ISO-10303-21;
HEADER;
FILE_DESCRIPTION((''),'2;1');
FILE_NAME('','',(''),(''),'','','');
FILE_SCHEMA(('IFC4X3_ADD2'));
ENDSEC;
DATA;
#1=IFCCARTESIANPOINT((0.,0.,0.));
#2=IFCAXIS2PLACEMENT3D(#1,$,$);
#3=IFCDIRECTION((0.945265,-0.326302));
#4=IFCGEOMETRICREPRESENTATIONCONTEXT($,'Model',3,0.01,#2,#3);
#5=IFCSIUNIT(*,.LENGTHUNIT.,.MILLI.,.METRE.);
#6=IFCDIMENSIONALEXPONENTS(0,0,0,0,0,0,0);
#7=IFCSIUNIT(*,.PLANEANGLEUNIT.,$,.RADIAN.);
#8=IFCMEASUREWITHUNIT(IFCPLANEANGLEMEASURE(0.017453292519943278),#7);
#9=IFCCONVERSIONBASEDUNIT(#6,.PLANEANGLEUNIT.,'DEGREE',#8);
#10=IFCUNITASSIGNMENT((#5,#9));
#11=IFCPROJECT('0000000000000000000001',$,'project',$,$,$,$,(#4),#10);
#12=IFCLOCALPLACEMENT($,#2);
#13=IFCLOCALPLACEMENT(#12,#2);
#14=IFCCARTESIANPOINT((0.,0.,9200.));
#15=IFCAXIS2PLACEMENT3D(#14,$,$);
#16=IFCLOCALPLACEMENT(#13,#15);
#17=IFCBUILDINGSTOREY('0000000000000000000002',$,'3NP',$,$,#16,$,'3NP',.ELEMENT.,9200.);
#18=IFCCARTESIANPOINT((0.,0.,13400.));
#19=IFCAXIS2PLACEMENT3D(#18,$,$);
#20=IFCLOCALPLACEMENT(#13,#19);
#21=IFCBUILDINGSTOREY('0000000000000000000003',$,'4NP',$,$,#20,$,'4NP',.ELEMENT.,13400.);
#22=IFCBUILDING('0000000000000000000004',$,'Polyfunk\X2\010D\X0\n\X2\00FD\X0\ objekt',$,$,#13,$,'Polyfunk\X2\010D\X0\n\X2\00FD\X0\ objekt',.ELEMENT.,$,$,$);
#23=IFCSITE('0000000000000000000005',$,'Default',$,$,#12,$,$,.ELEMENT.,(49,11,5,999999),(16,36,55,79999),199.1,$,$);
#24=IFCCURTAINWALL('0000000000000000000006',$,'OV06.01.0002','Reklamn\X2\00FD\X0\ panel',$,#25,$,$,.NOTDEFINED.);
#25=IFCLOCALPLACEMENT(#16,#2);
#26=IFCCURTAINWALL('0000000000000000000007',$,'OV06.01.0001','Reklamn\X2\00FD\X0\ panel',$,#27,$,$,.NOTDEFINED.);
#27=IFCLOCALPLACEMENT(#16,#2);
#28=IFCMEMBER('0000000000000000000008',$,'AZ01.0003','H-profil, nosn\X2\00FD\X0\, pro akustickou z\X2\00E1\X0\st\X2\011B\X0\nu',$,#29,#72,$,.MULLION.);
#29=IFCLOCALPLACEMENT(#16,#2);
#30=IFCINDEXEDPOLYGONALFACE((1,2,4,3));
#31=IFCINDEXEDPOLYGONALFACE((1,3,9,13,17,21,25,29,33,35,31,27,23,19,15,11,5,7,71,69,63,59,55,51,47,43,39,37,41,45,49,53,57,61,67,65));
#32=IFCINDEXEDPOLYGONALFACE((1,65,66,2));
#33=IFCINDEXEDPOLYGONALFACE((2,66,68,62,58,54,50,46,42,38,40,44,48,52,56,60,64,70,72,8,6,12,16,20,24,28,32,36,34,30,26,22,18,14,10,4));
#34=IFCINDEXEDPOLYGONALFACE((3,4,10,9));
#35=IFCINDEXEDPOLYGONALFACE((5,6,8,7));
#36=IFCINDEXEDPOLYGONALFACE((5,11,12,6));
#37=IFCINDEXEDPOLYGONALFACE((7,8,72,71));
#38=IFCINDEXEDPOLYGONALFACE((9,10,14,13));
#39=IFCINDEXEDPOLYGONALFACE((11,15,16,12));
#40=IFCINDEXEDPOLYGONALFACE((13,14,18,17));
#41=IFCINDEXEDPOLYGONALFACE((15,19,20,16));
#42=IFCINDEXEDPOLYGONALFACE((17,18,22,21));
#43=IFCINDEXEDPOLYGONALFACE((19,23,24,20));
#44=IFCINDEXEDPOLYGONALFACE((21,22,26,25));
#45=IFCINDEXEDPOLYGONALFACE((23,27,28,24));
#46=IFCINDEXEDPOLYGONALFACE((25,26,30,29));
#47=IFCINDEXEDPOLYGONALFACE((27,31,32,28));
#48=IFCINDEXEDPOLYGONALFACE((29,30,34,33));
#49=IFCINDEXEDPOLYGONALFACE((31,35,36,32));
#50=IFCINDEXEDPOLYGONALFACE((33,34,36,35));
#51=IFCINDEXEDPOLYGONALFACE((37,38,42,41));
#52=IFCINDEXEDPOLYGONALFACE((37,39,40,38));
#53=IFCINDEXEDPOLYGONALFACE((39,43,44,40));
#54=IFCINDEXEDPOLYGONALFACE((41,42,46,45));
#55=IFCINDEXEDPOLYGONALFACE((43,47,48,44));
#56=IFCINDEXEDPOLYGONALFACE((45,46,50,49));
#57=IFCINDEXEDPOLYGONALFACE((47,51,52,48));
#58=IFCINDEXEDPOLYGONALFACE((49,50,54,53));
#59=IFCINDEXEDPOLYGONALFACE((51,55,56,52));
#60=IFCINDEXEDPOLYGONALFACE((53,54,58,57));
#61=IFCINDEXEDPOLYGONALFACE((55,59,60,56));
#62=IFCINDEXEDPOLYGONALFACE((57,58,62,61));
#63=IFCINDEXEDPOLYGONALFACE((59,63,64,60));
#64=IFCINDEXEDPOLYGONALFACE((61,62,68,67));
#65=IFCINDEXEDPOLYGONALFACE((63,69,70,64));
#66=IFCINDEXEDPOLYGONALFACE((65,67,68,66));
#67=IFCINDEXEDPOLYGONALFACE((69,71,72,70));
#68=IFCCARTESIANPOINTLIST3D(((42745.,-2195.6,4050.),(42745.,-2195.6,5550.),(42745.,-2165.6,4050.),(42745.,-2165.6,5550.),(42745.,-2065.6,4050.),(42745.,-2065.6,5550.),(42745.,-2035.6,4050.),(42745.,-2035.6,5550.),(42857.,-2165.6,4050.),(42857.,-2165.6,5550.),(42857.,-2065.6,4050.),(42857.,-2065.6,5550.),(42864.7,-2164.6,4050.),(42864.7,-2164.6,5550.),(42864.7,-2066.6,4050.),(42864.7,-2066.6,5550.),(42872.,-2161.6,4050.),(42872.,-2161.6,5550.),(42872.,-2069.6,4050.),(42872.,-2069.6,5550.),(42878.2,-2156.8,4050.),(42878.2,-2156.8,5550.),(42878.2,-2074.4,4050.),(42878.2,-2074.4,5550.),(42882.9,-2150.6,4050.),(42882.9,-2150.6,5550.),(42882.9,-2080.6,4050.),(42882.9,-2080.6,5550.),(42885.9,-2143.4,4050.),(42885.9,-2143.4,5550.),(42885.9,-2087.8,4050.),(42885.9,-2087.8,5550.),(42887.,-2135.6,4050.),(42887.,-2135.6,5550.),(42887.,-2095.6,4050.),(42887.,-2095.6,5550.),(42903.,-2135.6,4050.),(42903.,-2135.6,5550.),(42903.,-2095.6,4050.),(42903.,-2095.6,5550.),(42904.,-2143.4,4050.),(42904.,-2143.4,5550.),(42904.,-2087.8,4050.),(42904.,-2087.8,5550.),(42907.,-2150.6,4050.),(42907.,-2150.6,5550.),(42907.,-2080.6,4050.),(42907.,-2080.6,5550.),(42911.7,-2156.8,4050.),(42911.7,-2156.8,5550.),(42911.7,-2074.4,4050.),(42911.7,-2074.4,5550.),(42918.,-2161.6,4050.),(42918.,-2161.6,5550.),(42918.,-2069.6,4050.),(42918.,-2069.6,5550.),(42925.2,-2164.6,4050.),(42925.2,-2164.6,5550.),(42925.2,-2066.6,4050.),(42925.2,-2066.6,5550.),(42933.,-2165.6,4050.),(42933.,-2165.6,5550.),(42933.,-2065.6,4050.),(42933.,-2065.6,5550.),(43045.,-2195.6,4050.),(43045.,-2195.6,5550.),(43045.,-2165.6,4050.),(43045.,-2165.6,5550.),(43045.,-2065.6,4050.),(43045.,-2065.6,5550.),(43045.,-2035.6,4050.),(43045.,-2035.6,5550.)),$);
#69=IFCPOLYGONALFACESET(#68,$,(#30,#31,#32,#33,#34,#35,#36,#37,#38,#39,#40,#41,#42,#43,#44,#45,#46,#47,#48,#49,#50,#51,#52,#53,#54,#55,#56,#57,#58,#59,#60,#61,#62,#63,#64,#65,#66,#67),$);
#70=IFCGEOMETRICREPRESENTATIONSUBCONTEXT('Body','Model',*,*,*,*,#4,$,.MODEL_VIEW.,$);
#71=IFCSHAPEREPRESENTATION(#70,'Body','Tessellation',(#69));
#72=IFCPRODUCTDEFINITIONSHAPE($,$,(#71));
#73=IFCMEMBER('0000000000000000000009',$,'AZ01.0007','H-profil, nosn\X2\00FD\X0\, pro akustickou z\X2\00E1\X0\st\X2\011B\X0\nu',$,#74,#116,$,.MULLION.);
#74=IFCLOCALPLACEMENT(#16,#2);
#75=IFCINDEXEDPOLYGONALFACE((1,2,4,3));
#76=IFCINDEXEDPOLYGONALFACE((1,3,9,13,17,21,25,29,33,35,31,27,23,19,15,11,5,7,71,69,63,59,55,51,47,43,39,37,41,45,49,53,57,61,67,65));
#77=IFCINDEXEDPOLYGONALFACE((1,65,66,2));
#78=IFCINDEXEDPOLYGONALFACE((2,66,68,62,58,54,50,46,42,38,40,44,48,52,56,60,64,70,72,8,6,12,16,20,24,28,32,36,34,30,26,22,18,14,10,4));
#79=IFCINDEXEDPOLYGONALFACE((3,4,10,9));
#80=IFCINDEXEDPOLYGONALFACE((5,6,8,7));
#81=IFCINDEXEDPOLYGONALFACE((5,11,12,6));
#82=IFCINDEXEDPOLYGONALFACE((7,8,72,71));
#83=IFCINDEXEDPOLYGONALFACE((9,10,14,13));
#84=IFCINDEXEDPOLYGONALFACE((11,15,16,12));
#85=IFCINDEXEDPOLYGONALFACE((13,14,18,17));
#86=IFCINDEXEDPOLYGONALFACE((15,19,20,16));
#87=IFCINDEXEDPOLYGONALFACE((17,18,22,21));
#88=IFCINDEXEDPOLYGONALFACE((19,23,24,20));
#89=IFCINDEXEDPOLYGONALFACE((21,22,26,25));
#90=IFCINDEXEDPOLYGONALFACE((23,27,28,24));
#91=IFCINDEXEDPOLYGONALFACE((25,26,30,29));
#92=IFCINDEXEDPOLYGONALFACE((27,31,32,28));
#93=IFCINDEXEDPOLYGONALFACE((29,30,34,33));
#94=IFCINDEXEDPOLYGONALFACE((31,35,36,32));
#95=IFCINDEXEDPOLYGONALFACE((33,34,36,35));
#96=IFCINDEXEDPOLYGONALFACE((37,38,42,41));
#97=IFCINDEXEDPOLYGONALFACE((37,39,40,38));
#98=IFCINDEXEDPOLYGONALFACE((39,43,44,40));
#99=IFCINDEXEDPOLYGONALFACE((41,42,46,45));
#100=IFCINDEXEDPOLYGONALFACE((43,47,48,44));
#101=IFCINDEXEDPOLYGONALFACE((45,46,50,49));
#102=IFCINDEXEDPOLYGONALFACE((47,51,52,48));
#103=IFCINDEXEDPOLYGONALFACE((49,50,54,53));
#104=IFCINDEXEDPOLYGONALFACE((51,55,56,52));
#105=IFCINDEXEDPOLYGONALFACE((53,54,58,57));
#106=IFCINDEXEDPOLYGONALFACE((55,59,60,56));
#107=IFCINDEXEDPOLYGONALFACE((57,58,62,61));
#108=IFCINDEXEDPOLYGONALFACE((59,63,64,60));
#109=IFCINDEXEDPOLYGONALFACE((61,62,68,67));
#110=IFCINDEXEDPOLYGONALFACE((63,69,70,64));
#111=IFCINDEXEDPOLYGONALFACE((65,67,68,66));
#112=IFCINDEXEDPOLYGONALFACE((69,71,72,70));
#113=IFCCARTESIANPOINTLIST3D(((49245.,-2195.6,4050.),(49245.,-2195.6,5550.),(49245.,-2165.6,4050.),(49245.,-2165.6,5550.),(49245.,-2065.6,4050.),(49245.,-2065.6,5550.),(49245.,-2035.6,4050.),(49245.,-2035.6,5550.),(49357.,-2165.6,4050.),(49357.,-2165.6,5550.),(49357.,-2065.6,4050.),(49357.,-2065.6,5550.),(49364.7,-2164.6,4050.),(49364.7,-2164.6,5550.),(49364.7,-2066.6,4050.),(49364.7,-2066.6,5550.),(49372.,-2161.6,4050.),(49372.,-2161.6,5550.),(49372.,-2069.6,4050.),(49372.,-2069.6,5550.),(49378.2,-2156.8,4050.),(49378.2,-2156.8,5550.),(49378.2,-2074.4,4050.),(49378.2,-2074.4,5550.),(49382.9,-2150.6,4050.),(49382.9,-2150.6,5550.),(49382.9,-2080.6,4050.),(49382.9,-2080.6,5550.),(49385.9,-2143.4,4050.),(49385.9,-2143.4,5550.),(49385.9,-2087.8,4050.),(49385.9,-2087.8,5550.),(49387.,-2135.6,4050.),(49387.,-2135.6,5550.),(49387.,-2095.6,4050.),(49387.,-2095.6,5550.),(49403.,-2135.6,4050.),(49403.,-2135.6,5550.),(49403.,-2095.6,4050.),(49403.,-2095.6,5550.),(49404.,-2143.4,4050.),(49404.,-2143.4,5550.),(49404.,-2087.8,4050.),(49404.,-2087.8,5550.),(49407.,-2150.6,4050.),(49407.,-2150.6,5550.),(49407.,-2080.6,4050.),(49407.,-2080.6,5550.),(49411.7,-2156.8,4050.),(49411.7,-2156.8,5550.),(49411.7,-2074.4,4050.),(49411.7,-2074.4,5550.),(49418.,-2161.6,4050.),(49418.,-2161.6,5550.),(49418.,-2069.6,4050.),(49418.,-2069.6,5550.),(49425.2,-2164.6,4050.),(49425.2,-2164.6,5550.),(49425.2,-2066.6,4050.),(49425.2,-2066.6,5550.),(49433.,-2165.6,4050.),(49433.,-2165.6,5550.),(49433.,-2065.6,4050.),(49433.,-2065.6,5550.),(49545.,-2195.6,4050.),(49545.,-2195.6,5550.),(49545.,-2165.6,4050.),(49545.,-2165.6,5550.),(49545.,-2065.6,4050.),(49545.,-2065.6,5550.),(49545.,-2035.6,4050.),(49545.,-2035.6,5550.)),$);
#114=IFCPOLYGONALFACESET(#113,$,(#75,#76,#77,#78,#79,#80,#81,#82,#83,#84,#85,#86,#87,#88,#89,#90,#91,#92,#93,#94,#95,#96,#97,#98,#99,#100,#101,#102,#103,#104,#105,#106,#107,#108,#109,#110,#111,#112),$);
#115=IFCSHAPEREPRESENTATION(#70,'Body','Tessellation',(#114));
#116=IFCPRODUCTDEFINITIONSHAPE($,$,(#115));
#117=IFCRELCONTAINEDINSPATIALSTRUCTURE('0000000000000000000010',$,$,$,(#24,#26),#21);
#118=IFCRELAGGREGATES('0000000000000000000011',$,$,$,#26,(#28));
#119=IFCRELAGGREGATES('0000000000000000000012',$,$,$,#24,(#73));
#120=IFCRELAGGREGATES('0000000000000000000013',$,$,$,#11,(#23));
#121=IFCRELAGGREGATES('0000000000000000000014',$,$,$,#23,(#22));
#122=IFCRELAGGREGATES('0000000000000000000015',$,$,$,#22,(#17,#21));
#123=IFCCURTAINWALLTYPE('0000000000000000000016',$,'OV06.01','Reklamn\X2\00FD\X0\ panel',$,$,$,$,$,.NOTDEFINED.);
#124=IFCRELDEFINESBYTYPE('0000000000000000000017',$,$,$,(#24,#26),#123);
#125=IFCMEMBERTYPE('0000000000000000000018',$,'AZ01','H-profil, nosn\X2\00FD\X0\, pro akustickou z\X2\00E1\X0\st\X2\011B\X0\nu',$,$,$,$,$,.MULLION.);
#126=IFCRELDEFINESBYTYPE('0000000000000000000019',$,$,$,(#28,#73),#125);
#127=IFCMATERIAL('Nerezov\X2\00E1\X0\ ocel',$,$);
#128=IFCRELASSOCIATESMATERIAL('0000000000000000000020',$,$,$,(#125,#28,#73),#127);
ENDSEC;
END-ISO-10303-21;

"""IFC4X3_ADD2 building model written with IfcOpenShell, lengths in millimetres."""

from ifc_helpers import new_model, entity, si_unit, converted_unit, direction, frame, frame_2d, origin, place, context, subcontext, project, spatial, polyline, circle_curve, parameter, trimmed, segment, composite_curve, outline, extrude, source, transform, mapped, material, material_profile, profile_set, profile_usage, type_object, element, aggregate, save


model = new_model("IFC4X3_ADD2")

# Units and contexts
model_context = context("Model", 3, precision=0.01, world=origin(), true_north=direction((0.945265, -0.326302)))
body_context = subcontext(model_context, "Body", "Model", "MODEL_VIEW")
ifc_project = project(units=[si_unit("LENGTHUNIT", "METRE", prefix="MILLI"), converted_unit("PLANEANGLEUNIT", "DEGREE", entity("IfcPlaneAngleMeasure", 0.017453292519943278), si_unit("PLANEANGLEUNIT", "RADIAN"), dimensions=[0, 0, 0, 0, 0, 0, 0])], contexts=[model_context])

# Site, building, storey
site_placement = place(None, origin())
site = spatial("IfcSite", under=ifc_project, at=site_placement, Name="Default", CompositionType="ELEMENT", RefLatitude=(49, 11, 5, 999999), RefLongitude=(16, 36, 55, 79999), RefElevation=199.1)
building_placement = place(site_placement, origin())
building = spatial("IfcBuilding", under=site, at=building_placement, Name="Polyfunkčný objekt", LongName="Polyfunkčný objekt", CompositionType="ELEMENT")
storey_1_placement = place(building_placement, frame((0.0, 0.0, 9200.0)))
storey_1 = spatial("IfcBuildingStorey", under=building, at=storey_1_placement, Name="3NP", LongName="3NP", CompositionType="ELEMENT", Elevation=9200.0)

# Shared definitions
storey_2_placement = place(building_placement, frame((0.0, 0.0, 13400.0)))
storey_2 = spatial("IfcBuildingStorey", under=building, at=storey_2_placement, Name="4NP", LongName="4NP", CompositionType="ELEMENT", Elevation=13400.0)

# Shared definitions
ifc_material_1 = material(Name="Nerezová ocel")
ifc_material_profile_1 = material_profile(ifc_material_1, outline(composite_curve([segment(polyline([(50.0, -150.0), (80.0, -150.0)]), True, "CONTINUOUS"), segment(polyline([(80.0, -150.0), (80.0, 150.0)]), True, "CONTINUOUS"), segment(polyline([(80.0, 150.0), (50.0, 150.0)]), True, "CONTINUOUS"), segment(polyline([(50.0, 150.0), (50.0, 38.0)]), True, "CONTINUOUS"), segment(trimmed(circle_curve(frame_2d((20.0, 38.0), x_axis=(0.0, 1.0)), 30.0), [parameter(180.0)], [parameter(270.0)], True, "PARAMETER"), False, "CONTINUOUS"), segment(polyline([(20.0, 8.0), (-20.0, 8.0)]), True, "CONTINUOUS"), segment(trimmed(circle_curve(frame_2d((-20.0, 38.0), x_axis=(0.0, 1.0)), 30.0), [parameter(90.0)], [parameter(180.0)], True, "PARAMETER"), False, "CONTINUOUS"), segment(polyline([(-50.0, 38.0), (-50.0, 150.0)]), True, "CONTINUOUS"), segment(polyline([(-50.0, 150.0), (-80.0, 150.0)]), True, "CONTINUOUS"), segment(polyline([(-80.0, 150.0), (-80.0, -150.0)]), True, "CONTINUOUS"), segment(polyline([(-80.0, -150.0), (-50.0, -150.0)]), True, "CONTINUOUS"), segment(polyline([(-50.0, -150.0), (-50.0, -38.0)]), True, "CONTINUOUS"), segment(trimmed(circle_curve(frame_2d((-20.0, -38.0), x_axis=(0.0, 1.0)), 30.0), [parameter(0.0)], [parameter(90.0)], True, "PARAMETER"), False, "CONTINUOUS"), segment(polyline([(-20.0, -8.0), (20.0, -8.0)]), True, "CONTINUOUS"), segment(trimmed(circle_curve(frame_2d((20.0, -38.0), x_axis=(0.0, 1.0)), 30.0), [parameter(270.0)], [parameter(0.0)], True, "PARAMETER"), False, "CONTINUOUS"), segment(polyline([(50.0, -38.0), (50.0, -150.0)]), True, "CONTINUOUS")], self_intersect=False)), Name="Profil zástena")
ifc_profile_set_1 = profile_set([ifc_material_profile_1], Name="Profil zástena")
ifc_profile_usage_1 = profile_usage(ifc_profile_set_1)
member_type_1 = type_object("IfcMemberType", Name="AZ01", Description="H-profil, nosný, pro akustickou zástěnu", PredefinedType="MULLION", material=ifc_profile_set_1)

# Curtain walls, member
curtain_wall_type_1 = type_object("IfcCurtainWallType", Name="OV06.01", Description="Reklamný panel", PredefinedType="NOTDEFINED")
curtain_wall_1_placement = place(storey_2_placement, frame((0.0, 0.0, -13400.0)))
curtain_wall_1 = element("IfcCurtainWall", 1, at=curtain_wall_1_placement, inside=storey_2, type_object=curtain_wall_type_1, Name="OV06.01.0002", Description="Reklamný panel", PredefinedType="NOTDEFINED")
curtain_wall_2_placement = place(storey_2_placement, frame((0.0, 0.0, -13400.0)))
curtain_wall_2 = element("IfcCurtainWall", 2, at=curtain_wall_2_placement, inside=storey_2, type_object=curtain_wall_type_1, Name="OV06.01.0001", Description="Reklamný panel", PredefinedType="NOTDEFINED")
shared_shape_1 = source(origin(), body_context, "Body", "SweptSolid", [
    extrude(outline(composite_curve([segment(polyline([(-150.0, -50.0), (-150.0, -80.0)]), True, "CONTINUOUS"), segment(polyline([(-150.0, -80.0), (150.0, -80.0)]), True, "CONTINUOUS"), segment(polyline([(150.0, -80.0), (150.0, -50.0)]), True, "CONTINUOUS"), segment(polyline([(150.0, -50.0), (38.0, -50.0)]), True, "CONTINUOUS"), segment(trimmed(circle_curve(frame_2d((38.0, -20.0), x_axis=(1.0, 0.0)), 30.0), [parameter(180.0)], [parameter(270.0)], True, "PARAMETER"), False, "CONTINUOUS"), segment(polyline([(8.0, -20.0), (8.0, 20.0)]), True, "CONTINUOUS"), segment(trimmed(circle_curve(frame_2d((38.0, 20.0), x_axis=(1.0, 0.0)), 30.0), [parameter(90.0)], [parameter(180.0)], True, "PARAMETER"), False, "CONTINUOUS"), segment(polyline([(38.0, 50.0), (150.0, 50.0)]), True, "CONTINUOUS"), segment(polyline([(150.0, 50.0), (150.0, 80.0)]), True, "CONTINUOUS"), segment(polyline([(150.0, 80.0), (-150.0, 80.0)]), True, "CONTINUOUS"), segment(polyline([(-150.0, 80.0), (-150.0, 50.0)]), True, "CONTINUOUS"), segment(polyline([(-150.0, 50.0), (-38.0, 50.0)]), True, "CONTINUOUS"), segment(trimmed(circle_curve(frame_2d((-38.0, 20.0), x_axis=(1.0, 0.0)), 30.0), [parameter(0.0)], [parameter(90.0)], True, "PARAMETER"), False, "CONTINUOUS"), segment(polyline([(-8.0, 20.0), (-8.0, -20.0)]), True, "CONTINUOUS"), segment(trimmed(circle_curve(frame_2d((-38.0, -20.0), x_axis=(1.0, 0.0)), 30.0), [parameter(270.0)], [parameter(0.0)], True, "PARAMETER"), False, "CONTINUOUS"), segment(polyline([(-38.0, -50.0), (-150.0, -50.0)]), True, "CONTINUOUS")], self_intersect=False)), frame((-150.0, 0.0, -1500.0), z_axis=(0.0, 0.0, -1.0), x_axis=(1.0, 0.0, 0.0)), (0.0, 0.0, -1.0), 1500.0),
])
member_1_placement = place(curtain_wall_2_placement, frame((43045.0, -2115.6, 13250.0), z_axis=(0.0, 0.0, -1.0), x_axis=(1.0, 0.0, 0.0)))
member_1 = element("IfcMember", 3, at=member_1_placement, type_object=member_type_1, material=ifc_profile_usage_1, Name="AZ01.0003", Description="H-profil, nosný, pro akustickou zástěnu", PredefinedType="MULLION", context=body_context, shape_type="MappedRepresentation", body=[
    mapped(shared_shape_1, transform((0.0, 0.0, 0.0), scale=1.0)),
])

# Member
member_2_placement = place(curtain_wall_1_placement, frame((49545.0, -2115.6, 13250.0), z_axis=(0.0, 0.0, -1.0), x_axis=(1.0, 0.0, 0.0)))
member_2 = element("IfcMember", 4, at=member_2_placement, type_object=member_type_1, material=ifc_profile_usage_1, Name="AZ01.0007", Description="H-profil, nosný, pro akustickou zástěnu", PredefinedType="MULLION", context=body_context, shape_type="MappedRepresentation", body=[
    mapped(shared_shape_1, transform((0.0, 0.0, 0.0), scale=1.0)),
])
aggregate(curtain_wall_2, [member_1])

aggregate(curtain_wall_1, [member_2])

save(model, "model.ifc")
